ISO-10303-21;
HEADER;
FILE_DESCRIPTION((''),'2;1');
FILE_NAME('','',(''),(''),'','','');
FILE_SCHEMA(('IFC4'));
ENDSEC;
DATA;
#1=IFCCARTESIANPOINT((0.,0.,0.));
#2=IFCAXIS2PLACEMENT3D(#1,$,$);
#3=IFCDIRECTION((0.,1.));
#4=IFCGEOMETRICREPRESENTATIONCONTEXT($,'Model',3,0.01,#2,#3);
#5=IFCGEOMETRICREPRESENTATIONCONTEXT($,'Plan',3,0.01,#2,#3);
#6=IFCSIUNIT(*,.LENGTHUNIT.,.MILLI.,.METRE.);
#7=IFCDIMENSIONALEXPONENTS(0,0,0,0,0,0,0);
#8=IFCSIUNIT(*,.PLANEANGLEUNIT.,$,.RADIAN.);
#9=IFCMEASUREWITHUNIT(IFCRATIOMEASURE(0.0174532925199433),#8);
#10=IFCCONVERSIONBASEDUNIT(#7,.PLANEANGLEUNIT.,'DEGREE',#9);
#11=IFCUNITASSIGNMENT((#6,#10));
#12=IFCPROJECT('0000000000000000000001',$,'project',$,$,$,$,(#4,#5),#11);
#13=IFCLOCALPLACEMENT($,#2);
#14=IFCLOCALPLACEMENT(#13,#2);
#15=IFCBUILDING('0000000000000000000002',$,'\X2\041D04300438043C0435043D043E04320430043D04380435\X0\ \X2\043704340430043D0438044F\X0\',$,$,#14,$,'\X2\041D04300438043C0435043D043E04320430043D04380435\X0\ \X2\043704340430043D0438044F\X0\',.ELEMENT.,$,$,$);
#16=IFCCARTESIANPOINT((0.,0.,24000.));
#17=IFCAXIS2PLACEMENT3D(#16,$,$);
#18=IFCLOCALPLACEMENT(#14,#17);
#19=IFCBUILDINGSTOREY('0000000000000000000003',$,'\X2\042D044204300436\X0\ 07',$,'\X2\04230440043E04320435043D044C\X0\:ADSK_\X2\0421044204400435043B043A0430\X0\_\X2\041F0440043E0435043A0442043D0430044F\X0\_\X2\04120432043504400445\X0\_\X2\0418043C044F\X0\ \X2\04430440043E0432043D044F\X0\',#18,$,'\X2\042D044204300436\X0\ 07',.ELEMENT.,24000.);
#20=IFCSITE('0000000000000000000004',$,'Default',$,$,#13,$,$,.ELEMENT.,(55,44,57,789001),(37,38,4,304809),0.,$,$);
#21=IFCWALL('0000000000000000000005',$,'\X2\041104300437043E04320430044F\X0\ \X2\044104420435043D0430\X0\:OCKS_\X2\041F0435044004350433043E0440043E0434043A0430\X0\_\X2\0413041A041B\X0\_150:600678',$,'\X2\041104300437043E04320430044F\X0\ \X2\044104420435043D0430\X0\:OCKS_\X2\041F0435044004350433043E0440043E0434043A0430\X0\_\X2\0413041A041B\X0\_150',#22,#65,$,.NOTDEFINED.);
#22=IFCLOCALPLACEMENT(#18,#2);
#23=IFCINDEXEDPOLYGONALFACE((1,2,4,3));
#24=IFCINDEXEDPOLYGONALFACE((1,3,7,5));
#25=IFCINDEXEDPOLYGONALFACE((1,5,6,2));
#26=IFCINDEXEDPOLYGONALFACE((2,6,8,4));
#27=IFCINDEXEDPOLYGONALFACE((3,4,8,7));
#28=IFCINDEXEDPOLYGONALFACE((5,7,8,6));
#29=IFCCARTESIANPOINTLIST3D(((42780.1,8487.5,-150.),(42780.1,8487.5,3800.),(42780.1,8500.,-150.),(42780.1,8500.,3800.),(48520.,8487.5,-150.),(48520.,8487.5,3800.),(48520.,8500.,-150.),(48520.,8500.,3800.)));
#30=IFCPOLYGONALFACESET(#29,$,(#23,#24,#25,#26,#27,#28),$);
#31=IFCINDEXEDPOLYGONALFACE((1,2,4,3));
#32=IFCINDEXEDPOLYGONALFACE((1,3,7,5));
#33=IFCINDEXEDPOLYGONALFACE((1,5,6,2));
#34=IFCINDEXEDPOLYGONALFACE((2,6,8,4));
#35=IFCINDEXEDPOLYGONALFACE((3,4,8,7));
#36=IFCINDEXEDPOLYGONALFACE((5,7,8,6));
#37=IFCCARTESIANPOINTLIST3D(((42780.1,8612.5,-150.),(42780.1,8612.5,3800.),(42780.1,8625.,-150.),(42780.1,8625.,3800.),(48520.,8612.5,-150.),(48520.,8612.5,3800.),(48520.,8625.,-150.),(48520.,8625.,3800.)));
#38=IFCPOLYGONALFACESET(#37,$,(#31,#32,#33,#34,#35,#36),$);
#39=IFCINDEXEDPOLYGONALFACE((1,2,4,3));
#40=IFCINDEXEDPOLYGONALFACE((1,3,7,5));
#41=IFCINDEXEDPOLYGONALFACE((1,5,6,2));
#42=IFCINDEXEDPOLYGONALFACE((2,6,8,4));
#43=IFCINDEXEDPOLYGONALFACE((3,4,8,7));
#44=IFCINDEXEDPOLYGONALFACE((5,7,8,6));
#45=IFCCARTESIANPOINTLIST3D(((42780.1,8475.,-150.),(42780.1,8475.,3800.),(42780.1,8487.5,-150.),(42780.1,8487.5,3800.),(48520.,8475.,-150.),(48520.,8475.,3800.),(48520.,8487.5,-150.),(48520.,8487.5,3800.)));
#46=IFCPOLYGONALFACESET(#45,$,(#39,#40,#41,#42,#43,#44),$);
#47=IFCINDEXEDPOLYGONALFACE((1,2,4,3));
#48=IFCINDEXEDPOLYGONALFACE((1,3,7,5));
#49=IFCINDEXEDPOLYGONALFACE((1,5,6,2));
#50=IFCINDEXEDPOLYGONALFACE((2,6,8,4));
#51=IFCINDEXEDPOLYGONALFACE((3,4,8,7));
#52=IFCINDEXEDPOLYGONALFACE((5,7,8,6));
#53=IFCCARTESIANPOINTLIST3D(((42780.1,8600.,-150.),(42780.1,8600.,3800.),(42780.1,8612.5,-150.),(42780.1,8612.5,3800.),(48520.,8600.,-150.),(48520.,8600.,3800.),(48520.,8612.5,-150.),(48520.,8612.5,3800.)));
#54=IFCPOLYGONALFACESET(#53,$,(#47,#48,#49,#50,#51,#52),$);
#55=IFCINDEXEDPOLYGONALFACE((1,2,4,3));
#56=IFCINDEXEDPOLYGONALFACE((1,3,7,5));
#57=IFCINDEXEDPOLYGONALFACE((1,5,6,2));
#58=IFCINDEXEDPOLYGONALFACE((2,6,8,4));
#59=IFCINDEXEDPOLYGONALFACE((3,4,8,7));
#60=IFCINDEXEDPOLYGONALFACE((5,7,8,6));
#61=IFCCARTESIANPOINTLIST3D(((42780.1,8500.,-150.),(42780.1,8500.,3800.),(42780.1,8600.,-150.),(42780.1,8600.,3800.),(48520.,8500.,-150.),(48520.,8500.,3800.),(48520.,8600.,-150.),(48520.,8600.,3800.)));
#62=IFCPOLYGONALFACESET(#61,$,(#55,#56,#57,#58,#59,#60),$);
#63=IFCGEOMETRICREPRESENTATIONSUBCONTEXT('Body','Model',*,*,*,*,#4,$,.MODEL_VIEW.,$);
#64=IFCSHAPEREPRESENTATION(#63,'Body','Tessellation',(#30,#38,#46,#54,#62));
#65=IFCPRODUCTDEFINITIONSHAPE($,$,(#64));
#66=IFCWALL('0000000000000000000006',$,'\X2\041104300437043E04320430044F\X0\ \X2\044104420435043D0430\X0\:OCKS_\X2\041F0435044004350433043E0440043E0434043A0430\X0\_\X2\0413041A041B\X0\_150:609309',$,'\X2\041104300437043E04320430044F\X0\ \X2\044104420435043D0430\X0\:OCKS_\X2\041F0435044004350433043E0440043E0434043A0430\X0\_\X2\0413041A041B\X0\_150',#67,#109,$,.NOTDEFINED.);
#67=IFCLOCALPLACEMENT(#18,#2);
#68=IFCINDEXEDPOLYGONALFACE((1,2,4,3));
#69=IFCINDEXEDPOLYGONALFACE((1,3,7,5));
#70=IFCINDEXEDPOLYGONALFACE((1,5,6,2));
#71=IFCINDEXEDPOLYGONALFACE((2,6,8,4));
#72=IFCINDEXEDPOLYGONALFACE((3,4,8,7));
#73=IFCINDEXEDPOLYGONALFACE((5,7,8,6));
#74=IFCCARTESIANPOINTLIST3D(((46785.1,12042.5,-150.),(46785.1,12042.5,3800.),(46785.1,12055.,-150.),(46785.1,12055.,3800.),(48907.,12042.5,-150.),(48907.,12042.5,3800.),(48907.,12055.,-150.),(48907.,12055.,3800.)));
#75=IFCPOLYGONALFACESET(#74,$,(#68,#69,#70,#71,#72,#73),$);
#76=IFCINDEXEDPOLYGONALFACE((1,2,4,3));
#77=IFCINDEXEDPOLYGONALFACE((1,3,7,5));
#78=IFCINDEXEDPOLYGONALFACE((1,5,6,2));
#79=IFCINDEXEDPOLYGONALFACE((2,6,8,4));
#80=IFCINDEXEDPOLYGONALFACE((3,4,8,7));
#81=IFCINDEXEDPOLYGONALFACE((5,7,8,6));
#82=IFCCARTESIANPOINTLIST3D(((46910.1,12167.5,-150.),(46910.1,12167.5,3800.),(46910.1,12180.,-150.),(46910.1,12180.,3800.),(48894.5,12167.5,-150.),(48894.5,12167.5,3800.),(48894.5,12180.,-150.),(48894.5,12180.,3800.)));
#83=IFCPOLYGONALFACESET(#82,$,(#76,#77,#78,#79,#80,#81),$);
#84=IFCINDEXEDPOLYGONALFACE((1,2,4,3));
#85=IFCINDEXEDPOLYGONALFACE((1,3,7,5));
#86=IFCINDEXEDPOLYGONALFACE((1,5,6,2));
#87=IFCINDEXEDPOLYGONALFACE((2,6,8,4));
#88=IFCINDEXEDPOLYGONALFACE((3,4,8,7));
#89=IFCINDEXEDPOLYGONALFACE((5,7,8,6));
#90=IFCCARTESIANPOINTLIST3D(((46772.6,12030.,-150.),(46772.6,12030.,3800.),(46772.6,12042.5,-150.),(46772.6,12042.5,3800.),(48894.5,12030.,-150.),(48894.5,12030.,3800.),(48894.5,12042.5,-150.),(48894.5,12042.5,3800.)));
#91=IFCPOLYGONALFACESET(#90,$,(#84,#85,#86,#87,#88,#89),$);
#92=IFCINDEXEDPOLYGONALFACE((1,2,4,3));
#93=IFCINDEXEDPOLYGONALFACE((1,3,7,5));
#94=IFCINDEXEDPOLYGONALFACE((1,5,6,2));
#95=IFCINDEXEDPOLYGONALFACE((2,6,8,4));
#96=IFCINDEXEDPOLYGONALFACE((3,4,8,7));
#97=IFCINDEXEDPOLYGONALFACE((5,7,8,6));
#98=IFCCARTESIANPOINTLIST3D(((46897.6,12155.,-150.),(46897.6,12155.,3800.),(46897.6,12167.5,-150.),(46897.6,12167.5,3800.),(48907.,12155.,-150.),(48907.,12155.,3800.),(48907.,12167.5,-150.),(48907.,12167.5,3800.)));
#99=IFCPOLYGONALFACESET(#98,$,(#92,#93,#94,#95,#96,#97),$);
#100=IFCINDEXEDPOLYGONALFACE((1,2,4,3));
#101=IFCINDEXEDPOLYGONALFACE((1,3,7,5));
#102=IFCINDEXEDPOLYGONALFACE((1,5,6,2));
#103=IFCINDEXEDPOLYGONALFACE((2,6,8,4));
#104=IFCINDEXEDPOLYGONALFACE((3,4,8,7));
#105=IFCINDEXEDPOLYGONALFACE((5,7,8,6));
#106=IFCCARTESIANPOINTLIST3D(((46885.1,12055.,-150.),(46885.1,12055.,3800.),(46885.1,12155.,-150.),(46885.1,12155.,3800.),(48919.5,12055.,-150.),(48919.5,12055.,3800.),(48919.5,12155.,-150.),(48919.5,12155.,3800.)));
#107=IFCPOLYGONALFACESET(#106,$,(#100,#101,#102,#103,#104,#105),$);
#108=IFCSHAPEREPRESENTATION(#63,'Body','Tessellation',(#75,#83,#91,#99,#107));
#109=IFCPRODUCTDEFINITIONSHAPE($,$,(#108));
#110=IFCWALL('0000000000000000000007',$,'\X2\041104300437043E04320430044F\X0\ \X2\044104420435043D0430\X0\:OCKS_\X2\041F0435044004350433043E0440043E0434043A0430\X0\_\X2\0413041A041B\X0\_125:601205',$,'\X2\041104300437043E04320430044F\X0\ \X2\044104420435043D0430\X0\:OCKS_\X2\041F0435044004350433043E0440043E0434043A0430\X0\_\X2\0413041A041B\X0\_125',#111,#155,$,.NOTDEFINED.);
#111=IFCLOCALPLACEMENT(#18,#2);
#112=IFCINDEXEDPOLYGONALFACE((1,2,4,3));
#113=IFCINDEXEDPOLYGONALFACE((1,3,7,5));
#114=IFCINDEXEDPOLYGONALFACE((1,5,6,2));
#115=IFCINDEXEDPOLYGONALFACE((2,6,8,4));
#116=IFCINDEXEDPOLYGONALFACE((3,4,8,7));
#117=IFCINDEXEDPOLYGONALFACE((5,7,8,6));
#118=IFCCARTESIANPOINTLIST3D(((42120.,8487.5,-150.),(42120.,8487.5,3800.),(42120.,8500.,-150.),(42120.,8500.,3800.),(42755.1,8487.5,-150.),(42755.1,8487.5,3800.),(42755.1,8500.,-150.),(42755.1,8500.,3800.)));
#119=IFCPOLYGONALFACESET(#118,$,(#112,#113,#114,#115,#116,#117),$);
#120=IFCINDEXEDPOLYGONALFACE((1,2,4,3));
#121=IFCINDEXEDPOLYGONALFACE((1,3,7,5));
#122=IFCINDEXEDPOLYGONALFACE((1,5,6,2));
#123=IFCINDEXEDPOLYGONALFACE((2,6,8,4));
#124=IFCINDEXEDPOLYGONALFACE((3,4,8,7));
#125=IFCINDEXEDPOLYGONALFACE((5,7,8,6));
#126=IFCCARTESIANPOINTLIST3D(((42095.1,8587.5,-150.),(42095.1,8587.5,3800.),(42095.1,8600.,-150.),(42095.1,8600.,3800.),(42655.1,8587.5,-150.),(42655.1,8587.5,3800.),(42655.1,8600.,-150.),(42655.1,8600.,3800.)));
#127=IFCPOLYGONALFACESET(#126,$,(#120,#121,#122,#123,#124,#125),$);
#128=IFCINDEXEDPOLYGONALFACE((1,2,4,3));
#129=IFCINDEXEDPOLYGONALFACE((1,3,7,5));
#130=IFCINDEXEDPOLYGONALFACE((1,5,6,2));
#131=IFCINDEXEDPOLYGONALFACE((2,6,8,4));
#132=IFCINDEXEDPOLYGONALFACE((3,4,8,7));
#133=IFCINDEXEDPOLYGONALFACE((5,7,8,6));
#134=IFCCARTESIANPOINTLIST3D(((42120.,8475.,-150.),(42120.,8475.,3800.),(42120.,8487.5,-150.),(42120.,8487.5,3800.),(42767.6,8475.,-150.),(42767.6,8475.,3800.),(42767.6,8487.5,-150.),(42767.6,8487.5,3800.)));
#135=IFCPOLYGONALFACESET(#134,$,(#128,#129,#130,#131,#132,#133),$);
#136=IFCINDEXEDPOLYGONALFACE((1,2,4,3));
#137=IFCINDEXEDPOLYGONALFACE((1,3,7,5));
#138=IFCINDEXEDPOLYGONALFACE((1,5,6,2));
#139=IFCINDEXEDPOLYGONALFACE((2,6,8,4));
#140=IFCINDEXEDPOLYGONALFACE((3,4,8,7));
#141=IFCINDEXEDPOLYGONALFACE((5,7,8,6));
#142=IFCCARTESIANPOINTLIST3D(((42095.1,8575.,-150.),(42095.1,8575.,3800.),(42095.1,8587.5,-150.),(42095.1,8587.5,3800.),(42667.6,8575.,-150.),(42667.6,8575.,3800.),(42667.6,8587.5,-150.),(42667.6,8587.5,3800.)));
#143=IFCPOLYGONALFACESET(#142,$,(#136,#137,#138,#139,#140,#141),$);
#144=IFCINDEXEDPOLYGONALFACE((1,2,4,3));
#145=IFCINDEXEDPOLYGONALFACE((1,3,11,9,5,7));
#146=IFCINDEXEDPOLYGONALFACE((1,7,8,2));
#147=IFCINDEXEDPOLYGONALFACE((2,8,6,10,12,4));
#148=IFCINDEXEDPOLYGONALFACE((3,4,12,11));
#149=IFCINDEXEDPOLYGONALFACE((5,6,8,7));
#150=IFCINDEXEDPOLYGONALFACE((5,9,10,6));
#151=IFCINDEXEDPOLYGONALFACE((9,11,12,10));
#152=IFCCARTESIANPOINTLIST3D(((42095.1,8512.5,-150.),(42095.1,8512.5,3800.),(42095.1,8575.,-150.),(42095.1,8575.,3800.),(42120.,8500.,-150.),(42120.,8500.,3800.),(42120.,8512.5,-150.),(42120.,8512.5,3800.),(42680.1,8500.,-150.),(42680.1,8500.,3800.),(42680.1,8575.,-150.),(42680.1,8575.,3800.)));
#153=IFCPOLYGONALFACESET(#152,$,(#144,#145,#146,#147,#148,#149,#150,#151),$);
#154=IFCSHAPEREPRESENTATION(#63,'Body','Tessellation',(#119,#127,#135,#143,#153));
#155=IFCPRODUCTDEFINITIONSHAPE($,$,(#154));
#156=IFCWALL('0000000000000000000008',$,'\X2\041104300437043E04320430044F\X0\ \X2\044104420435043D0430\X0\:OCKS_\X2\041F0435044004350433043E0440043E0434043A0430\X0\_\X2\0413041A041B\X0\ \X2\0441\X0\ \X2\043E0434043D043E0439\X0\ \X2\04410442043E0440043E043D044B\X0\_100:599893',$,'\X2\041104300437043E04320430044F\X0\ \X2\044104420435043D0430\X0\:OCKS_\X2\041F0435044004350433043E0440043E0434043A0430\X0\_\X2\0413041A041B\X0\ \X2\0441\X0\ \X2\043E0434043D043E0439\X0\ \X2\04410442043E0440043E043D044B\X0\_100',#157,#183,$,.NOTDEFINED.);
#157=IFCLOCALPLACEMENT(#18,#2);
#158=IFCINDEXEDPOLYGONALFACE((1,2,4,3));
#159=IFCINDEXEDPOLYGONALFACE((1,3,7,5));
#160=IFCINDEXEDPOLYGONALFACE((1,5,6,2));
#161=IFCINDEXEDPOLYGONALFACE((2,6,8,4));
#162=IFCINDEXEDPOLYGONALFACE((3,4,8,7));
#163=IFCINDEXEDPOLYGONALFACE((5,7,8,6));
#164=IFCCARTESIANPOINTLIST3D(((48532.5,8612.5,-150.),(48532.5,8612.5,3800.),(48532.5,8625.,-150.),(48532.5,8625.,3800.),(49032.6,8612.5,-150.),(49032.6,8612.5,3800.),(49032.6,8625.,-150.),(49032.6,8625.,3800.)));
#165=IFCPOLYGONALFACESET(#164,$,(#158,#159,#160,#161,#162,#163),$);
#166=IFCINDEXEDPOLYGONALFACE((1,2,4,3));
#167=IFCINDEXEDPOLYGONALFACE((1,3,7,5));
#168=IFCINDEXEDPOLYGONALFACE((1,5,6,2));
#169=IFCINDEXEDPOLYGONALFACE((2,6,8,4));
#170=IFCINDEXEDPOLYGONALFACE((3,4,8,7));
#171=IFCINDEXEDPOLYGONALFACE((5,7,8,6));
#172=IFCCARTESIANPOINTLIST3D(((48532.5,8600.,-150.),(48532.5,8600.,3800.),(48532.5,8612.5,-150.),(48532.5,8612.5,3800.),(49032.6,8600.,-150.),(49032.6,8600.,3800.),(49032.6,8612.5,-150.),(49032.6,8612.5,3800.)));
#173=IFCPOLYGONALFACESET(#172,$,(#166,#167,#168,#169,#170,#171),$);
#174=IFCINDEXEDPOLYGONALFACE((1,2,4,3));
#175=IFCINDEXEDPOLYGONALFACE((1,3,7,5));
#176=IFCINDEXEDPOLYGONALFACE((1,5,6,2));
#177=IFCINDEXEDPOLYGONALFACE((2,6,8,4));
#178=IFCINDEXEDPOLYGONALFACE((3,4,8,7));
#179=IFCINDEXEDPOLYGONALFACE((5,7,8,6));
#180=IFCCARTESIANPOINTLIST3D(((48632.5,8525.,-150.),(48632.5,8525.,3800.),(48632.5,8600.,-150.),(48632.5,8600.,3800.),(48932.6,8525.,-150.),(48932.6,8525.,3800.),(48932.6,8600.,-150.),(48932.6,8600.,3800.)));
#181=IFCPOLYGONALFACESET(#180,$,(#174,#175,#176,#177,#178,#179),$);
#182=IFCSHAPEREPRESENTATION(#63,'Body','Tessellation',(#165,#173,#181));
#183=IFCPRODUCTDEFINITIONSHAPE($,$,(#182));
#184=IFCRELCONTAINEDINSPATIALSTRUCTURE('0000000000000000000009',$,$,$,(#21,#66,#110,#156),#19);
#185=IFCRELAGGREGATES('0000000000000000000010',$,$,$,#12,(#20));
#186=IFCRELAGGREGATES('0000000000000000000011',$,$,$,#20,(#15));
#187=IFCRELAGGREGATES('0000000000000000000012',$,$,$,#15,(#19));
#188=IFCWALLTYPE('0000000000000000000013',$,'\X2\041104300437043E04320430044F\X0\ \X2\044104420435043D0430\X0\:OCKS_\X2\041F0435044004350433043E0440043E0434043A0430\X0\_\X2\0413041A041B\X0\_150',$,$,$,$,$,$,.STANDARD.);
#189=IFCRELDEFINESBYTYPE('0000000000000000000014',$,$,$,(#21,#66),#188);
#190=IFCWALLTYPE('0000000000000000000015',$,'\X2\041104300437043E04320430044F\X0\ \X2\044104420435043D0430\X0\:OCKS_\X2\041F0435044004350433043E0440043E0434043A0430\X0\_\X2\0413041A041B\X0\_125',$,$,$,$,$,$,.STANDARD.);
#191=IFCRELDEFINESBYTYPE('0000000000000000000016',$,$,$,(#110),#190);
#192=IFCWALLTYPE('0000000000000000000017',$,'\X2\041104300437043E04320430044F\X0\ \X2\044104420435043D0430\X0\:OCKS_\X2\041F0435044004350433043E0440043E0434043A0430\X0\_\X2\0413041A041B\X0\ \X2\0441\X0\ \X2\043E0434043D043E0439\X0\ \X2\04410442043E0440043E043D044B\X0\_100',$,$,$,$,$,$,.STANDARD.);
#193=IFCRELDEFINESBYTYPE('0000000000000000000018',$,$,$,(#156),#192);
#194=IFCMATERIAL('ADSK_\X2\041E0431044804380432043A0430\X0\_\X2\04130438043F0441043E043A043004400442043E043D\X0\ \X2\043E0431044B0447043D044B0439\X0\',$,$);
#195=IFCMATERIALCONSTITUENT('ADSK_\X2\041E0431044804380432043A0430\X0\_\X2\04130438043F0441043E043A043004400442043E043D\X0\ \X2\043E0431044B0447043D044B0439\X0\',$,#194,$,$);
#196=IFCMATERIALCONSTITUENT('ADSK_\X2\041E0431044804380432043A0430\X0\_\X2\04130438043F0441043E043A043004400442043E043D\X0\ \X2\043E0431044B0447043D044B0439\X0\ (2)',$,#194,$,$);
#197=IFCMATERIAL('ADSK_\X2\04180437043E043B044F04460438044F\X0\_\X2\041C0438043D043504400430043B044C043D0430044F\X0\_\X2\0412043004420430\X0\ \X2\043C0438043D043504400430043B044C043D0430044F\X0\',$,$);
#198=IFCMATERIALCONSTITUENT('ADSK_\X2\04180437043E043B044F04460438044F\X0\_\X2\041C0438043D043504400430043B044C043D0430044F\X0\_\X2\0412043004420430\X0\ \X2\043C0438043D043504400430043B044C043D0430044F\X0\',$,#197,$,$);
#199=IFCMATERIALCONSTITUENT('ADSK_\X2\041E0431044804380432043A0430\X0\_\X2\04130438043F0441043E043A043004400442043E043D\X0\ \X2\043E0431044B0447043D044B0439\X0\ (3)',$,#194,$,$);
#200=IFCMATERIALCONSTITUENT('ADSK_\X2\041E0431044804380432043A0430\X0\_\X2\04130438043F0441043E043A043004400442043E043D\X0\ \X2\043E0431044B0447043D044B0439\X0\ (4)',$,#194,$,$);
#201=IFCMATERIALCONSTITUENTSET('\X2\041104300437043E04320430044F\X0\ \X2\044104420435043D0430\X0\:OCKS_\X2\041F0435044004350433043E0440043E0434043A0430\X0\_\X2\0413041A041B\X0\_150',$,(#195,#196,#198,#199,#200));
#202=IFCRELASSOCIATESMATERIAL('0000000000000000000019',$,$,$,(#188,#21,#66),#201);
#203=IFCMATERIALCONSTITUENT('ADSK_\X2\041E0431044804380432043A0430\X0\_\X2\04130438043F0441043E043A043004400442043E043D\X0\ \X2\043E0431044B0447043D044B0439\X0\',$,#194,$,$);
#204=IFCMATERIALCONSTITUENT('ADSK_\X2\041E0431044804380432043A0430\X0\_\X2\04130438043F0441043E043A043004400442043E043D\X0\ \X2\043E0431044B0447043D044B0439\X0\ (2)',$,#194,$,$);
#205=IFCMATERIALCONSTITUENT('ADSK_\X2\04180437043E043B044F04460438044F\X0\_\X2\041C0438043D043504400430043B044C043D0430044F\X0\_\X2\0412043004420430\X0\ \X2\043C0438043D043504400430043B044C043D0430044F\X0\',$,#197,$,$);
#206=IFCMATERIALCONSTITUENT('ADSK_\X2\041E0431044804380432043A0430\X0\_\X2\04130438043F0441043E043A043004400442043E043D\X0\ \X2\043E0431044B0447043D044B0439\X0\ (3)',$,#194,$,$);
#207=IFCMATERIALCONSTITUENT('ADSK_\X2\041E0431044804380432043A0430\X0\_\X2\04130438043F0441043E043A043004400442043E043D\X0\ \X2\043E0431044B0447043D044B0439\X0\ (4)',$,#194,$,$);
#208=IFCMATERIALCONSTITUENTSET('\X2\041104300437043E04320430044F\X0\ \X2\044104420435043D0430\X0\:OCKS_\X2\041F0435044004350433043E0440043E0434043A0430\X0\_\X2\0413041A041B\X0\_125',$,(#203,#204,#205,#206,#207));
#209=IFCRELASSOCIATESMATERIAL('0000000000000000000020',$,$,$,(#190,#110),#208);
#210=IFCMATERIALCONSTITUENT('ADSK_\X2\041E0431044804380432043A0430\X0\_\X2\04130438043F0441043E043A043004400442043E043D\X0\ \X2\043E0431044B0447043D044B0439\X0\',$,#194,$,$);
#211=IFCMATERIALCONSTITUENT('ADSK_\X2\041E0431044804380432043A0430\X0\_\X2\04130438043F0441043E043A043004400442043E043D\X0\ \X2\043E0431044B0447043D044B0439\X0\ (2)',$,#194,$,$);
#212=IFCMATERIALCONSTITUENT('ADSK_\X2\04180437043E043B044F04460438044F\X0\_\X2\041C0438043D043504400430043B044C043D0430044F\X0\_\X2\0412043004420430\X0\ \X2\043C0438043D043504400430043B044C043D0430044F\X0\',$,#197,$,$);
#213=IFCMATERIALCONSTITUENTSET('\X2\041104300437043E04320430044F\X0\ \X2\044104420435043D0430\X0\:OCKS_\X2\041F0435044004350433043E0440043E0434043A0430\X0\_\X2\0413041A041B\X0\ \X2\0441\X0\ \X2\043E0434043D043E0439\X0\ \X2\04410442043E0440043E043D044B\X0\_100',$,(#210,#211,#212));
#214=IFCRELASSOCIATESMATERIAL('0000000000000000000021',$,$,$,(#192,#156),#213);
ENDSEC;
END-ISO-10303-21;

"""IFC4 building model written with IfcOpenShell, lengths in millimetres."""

from ifc_helpers import new_model, entity, si_unit, converted_unit, direction, frame, origin, place, context, subcontext, project, spatial, indexed_curve, outline, extrude, material, constituent, constituent_set, type_object, element, save


model = new_model("IFC4")

# Units and contexts
model_context = context("Model", 3, precision=0.01, world=origin(), true_north=direction((0.0, 1.0)))
plan_context = context("Plan", 3, precision=0.01, world=origin(), true_north=direction((0.0, 1.0)))
body_context = subcontext(model_context, "Body", "Model", "MODEL_VIEW")
ifc_project = project(units=[si_unit("LENGTHUNIT", "METRE", prefix="MILLI"), converted_unit("PLANEANGLEUNIT", "DEGREE", entity("IfcRatioMeasure", 0.0174532925199433), si_unit("PLANEANGLEUNIT", "RADIAN"), dimensions=[0, 0, 0, 0, 0, 0, 0])], contexts=[model_context, plan_context])

# Site, building, storey
site_placement = place(None, frame((0.0, 0.0, 0.0)))
site = spatial("IfcSite", under=ifc_project, at=site_placement, Name="Default", CompositionType="ELEMENT", RefLatitude=(55, 44, 57, 789001), RefLongitude=(37, 38, 4, 304809), RefElevation=0.0)
building_placement = place(site_placement, origin())
building = spatial("IfcBuilding", under=site, at=building_placement, Name="Наименование здания", LongName="Наименование здания", CompositionType="ELEMENT")
storey_placement = place(building_placement, frame((0.0, 0.0, 24000.0)))
storey = spatial("IfcBuildingStorey", under=building, at=storey_placement, Name="Этаж 07", ObjectType="Уровень:ADSK_Стрелка_Проектная_Вверх_Имя уровня", LongName="Этаж 07", CompositionType="ELEMENT", Elevation=24000.0)

# Shared definitions
ifc_material_1 = material(Name="ADSK_Обшивка_Гипсокартон обычный")
ifc_constituent_1 = constituent(ifc_material_1, Name="ADSK_Обшивка_Гипсокартон обычный")
ifc_constituent_2 = constituent(ifc_material_1, Name="ADSK_Обшивка_Гипсокартон обычный (2)")
ifc_material_2 = material(Name="ADSK_Изоляция_Минеральная_Вата минеральная")
ifc_constituent_3 = constituent(ifc_material_2, Name="ADSK_Изоляция_Минеральная_Вата минеральная")
ifc_constituent_4 = constituent(ifc_material_1, Name="ADSK_Обшивка_Гипсокартон обычный (3)")
ifc_constituent_5 = constituent(ifc_material_1, Name="ADSK_Обшивка_Гипсокартон обычный (4)")
ifc_constituent_set_1 = constituent_set(constituents=[ifc_constituent_1, ifc_constituent_2, ifc_constituent_3, ifc_constituent_4, ifc_constituent_5], Name="Базовая стена:OCKS_Перегородка_ГКЛ_150")
wall_type_1 = type_object("IfcWallType", Name="Базовая стена:OCKS_Перегородка_ГКЛ_150", PredefinedType="STANDARD", material=ifc_constituent_set_1)

# Wall
wall_1_placement = place(storey_placement, frame((48520.0, 8550.0, -150.0), z_axis=(0.0, 0.0, 1.0), x_axis=(-1.0, 0.0, 0.0)))
element("IfcWall", 1, at=wall_1_placement, inside=storey, type_object=wall_type_1, material=ifc_constituent_set_1, Name="Базовая стена:OCKS_Перегородка_ГКЛ_150:600678", ObjectType="Базовая стена:OCKS_Перегородка_ГКЛ_150", PredefinedType="NOTDEFINED", context=body_context, shape_type="SweptSolid", body=[
    extrude(outline(indexed_curve([(-2869.9, -6.3), (2869.9, -6.3), (2869.9, 6.3), (-2869.9, 6.3), (-2869.9, -6.3)], self_intersect=False)), frame((2869.9, 56.3, 0.0)), (0.0, 0.0, 1.0), 3950.0),
    extrude(outline(indexed_curve([(-6.3, -2869.9), (6.2, -2869.9), (6.3, 2869.9), (-6.2, 2869.9), (-6.3, -2869.9)], self_intersect=False)), frame((2869.9, -68.7, 0.0), z_axis=(0.0, 0.0, 1.0), x_axis=(0.0, 1.0, 0.0)), (0.0, 0.0, 1.0), 3950.0),
    extrude(outline(indexed_curve([(-6.3, -2869.9), (6.2, -2869.9), (6.3, 2869.9), (-6.2, 2869.9), (-6.3, -2869.9)], self_intersect=False)), frame((2869.9, 68.8, 0.0), z_axis=(0.0, 0.0, 1.0), x_axis=(0.0, -1.0, 0.0)), (0.0, 0.0, 1.0), 3950.0),
    extrude(outline(indexed_curve([(-2869.9, -6.3), (2869.9, -6.3), (2869.9, 6.3), (-2869.9, 6.3), (-2869.9, -6.3)], self_intersect=False)), frame((2869.9, -56.2, 0.0)), (0.0, 0.0, 1.0), 3950.0),
    extrude(outline(indexed_curve([(-2869.9, -50.0), (2869.9, -50.0), (2869.9, 50.0), (-2869.9, 50.0), (-2869.9, -50.0)], self_intersect=False)), frame((2869.9, 0.0, 0.0)), (0.0, 0.0, 1.0), 3950.0),
])

# Wall
wall_2_placement = place(storey_placement, frame((46910.1, 12105.0, -150.0)))
element("IfcWall", 2, at=wall_2_placement, inside=storey, type_object=wall_type_1, material=ifc_constituent_set_1, Name="Базовая стена:OCKS_Перегородка_ГКЛ_150:609309", ObjectType="Базовая стена:OCKS_Перегородка_ГКЛ_150", PredefinedType="NOTDEFINED", context=body_context, shape_type="SweptSolid", body=[
    extrude(outline(indexed_curve([(-1061.0, -6.2), (1061.0, -6.2), (1061.0, 6.3), (-1061.0, 6.3), (-1061.0, -6.2)], self_intersect=False)), frame((936.0, -56.3, 0.0)), (0.0, 0.0, 1.0), 3950.0),
    extrude(outline(indexed_curve([(-6.3, -992.2), (6.2, -992.2), (6.3, 992.2), (-6.2, 992.2), (-6.3, -992.2)], self_intersect=False)), frame((992.2, 68.7, 0.0), z_axis=(0.0, 0.0, 1.0), x_axis=(0.0, -1.0, 0.0)), (0.0, 0.0, 1.0), 3950.0),
    extrude(outline(indexed_curve([(-6.3, -1061.0), (6.2, -1061.0), (6.3, 1061.0), (-6.2, 1061.0), (-6.3, -1061.0)], self_intersect=False)), frame((923.5, -68.8, 0.0), z_axis=(0.0, 0.0, 1.0), x_axis=(0.0, 1.0, 0.0)), (0.0, 0.0, 1.0), 3950.0),
    extrude(outline(indexed_curve([(-1004.7, -6.2), (1004.7, -6.2), (1004.7, 6.3), (-1004.7, 6.3), (-1004.7, -6.2)], self_intersect=False)), frame((992.2, 56.2, 0.0)), (0.0, 0.0, 1.0), 3950.0),
    extrude(outline(indexed_curve([(-1017.2, -50.0), (1017.2, -50.0), (1017.2, 50.0), (-1017.2, 50.0), (-1017.2, -50.0)], self_intersect=False)), frame((992.2, 0.0, 0.0)), (0.0, 0.0, 1.0), 3950.0),
])

# Walls
ifc_constituent_6 = constituent(ifc_material_1, Name="ADSK_Обшивка_Гипсокартон обычный")
ifc_constituent_7 = constituent(ifc_material_1, Name="ADSK_Обшивка_Гипсокартон обычный (2)")
ifc_constituent_8 = constituent(ifc_material_2, Name="ADSK_Изоляция_Минеральная_Вата минеральная")
ifc_constituent_9 = constituent(ifc_material_1, Name="ADSK_Обшивка_Гипсокартон обычный (3)")
ifc_constituent_10 = constituent(ifc_material_1, Name="ADSK_Обшивка_Гипсокартон обычный (4)")
ifc_constituent_set_2 = constituent_set(constituents=[ifc_constituent_6, ifc_constituent_7, ifc_constituent_8, ifc_constituent_9, ifc_constituent_10], Name="Базовая стена:OCKS_Перегородка_ГКЛ_125")
wall_type_2 = type_object("IfcWallType", Name="Базовая стена:OCKS_Перегородка_ГКЛ_125", PredefinedType="STANDARD", material=ifc_constituent_set_2)
wall_3_placement = place(storey_placement, frame((42095.1, 8537.5, -150.0)))
element("IfcWall", 3, at=wall_3_placement, inside=storey, type_object=wall_type_2, material=ifc_constituent_set_2, Name="Базовая стена:OCKS_Перегородка_ГКЛ_125:601205", ObjectType="Базовая стена:OCKS_Перегородка_ГКЛ_125", PredefinedType="NOTDEFINED", context=body_context, shape_type="SweptSolid", body=[
    extrude(outline(indexed_curve([(-317.6, -6.2), (317.6, -6.2), (317.6, 6.2), (-317.6, 6.2), (-317.6, -6.2)], self_intersect=False)), frame((342.4, -43.7, 0.0)), (0.0, 0.0, 1.0), 3950.0),
    extrude(outline(indexed_curve([(-6.3, -280.0), (6.2, -280.0), (6.3, 280.0), (-6.2, 280.0), (-6.3, -280.0)], self_intersect=False)), frame((280.0, 56.3, 0.0), z_axis=(0.0, 0.0, 1.0), x_axis=(0.0, -1.0, 0.0)), (0.0, 0.0, 1.0), 3950.0),
    extrude(outline(indexed_curve([(-6.3, -323.8), (6.2, -323.8), (6.3, 323.8), (-6.2, 323.8), (-6.3, -323.8)], self_intersect=False)), frame((348.7, -56.2, 0.0), z_axis=(0.0, 0.0, 1.0), x_axis=(0.0, 1.0, 0.0)), (0.0, 0.0, 1.0), 3950.0),
    extrude(outline(indexed_curve([(-286.2, -6.2), (286.2, -6.2), (286.2, 6.2), (-286.2, 6.2), (-286.2, -6.2)], self_intersect=False)), frame((286.2, 43.7, 0.0)), (0.0, 0.0, 1.0), 3950.0),
    extrude(outline(indexed_curve([(16.7, -178.4), (29.2, -178.4), (29.2, 381.7), (-45.8, 381.7), (-45.8, -203.3), (16.7, -203.3), (16.7, -178.4)], self_intersect=False)), frame((203.3, -8.3, 0.0), z_axis=(0.0, 0.0, 1.0), x_axis=(0.0, -1.0, 0.0)), (0.0, 0.0, 1.0), 3950.0),
])
ifc_constituent_11 = constituent(ifc_material_1, Name="ADSK_Обшивка_Гипсокартон обычный")
ifc_constituent_12 = constituent(ifc_material_1, Name="ADSK_Обшивка_Гипсокартон обычный (2)")
ifc_constituent_13 = constituent(ifc_material_2, Name="ADSK_Изоляция_Минеральная_Вата минеральная")
ifc_constituent_set_3 = constituent_set(constituents=[ifc_constituent_11, ifc_constituent_12, ifc_constituent_13], Name="Базовая стена:OCKS_Перегородка_ГКЛ с одной стороны_100")
wall_type_3 = type_object("IfcWallType", Name="Базовая стена:OCKS_Перегородка_ГКЛ с одной стороны_100", PredefinedType="STANDARD", material=ifc_constituent_set_3)
wall_4_placement = place(storey_placement, frame((48932.6, 8575.0, -150.0), z_axis=(0.0, 0.0, 1.0), x_axis=(-1.0, 0.0, 0.0)))
element("IfcWall", 4, at=wall_4_placement, inside=storey, type_object=wall_type_3, material=ifc_constituent_set_3, Name="Базовая стена:OCKS_Перегородка_ГКЛ с одной стороны_100:599893", ObjectType="Базовая стена:OCKS_Перегородка_ГКЛ с одной стороны_100", PredefinedType="NOTDEFINED", context=body_context, shape_type="SweptSolid", body=[
    extrude(outline(indexed_curve([(-6.3, -250.1), (6.2, -250.1), (6.3, 250.1), (-6.2, 250.1), (-6.3, -250.1)], self_intersect=False)), frame((150.1, -43.8, 0.0), z_axis=(0.0, 0.0, 1.0), x_axis=(0.0, 1.0, 0.0)), (0.0, 0.0, 1.0), 3950.0),
    extrude(outline(indexed_curve([(-250.1, -6.3), (250.1, -6.3), (250.1, 6.3), (-250.1, 6.3), (-250.1, -6.3)], self_intersect=False)), frame((150.1, -31.3, 0.0)), (0.0, 0.0, 1.0), 3950.0),
    extrude(outline(indexed_curve([(-37.5, -150.1), (37.5, -150.1), (37.5, 150.1), (-37.5, 150.1), (-37.5, -150.1)], self_intersect=False)), frame((150.1, 12.5, 0.0), z_axis=(0.0, 0.0, 1.0), x_axis=(0.0, -1.0, 0.0)), (0.0, 0.0, 1.0), 3950.0),
])

save(model, "model.ifc")
